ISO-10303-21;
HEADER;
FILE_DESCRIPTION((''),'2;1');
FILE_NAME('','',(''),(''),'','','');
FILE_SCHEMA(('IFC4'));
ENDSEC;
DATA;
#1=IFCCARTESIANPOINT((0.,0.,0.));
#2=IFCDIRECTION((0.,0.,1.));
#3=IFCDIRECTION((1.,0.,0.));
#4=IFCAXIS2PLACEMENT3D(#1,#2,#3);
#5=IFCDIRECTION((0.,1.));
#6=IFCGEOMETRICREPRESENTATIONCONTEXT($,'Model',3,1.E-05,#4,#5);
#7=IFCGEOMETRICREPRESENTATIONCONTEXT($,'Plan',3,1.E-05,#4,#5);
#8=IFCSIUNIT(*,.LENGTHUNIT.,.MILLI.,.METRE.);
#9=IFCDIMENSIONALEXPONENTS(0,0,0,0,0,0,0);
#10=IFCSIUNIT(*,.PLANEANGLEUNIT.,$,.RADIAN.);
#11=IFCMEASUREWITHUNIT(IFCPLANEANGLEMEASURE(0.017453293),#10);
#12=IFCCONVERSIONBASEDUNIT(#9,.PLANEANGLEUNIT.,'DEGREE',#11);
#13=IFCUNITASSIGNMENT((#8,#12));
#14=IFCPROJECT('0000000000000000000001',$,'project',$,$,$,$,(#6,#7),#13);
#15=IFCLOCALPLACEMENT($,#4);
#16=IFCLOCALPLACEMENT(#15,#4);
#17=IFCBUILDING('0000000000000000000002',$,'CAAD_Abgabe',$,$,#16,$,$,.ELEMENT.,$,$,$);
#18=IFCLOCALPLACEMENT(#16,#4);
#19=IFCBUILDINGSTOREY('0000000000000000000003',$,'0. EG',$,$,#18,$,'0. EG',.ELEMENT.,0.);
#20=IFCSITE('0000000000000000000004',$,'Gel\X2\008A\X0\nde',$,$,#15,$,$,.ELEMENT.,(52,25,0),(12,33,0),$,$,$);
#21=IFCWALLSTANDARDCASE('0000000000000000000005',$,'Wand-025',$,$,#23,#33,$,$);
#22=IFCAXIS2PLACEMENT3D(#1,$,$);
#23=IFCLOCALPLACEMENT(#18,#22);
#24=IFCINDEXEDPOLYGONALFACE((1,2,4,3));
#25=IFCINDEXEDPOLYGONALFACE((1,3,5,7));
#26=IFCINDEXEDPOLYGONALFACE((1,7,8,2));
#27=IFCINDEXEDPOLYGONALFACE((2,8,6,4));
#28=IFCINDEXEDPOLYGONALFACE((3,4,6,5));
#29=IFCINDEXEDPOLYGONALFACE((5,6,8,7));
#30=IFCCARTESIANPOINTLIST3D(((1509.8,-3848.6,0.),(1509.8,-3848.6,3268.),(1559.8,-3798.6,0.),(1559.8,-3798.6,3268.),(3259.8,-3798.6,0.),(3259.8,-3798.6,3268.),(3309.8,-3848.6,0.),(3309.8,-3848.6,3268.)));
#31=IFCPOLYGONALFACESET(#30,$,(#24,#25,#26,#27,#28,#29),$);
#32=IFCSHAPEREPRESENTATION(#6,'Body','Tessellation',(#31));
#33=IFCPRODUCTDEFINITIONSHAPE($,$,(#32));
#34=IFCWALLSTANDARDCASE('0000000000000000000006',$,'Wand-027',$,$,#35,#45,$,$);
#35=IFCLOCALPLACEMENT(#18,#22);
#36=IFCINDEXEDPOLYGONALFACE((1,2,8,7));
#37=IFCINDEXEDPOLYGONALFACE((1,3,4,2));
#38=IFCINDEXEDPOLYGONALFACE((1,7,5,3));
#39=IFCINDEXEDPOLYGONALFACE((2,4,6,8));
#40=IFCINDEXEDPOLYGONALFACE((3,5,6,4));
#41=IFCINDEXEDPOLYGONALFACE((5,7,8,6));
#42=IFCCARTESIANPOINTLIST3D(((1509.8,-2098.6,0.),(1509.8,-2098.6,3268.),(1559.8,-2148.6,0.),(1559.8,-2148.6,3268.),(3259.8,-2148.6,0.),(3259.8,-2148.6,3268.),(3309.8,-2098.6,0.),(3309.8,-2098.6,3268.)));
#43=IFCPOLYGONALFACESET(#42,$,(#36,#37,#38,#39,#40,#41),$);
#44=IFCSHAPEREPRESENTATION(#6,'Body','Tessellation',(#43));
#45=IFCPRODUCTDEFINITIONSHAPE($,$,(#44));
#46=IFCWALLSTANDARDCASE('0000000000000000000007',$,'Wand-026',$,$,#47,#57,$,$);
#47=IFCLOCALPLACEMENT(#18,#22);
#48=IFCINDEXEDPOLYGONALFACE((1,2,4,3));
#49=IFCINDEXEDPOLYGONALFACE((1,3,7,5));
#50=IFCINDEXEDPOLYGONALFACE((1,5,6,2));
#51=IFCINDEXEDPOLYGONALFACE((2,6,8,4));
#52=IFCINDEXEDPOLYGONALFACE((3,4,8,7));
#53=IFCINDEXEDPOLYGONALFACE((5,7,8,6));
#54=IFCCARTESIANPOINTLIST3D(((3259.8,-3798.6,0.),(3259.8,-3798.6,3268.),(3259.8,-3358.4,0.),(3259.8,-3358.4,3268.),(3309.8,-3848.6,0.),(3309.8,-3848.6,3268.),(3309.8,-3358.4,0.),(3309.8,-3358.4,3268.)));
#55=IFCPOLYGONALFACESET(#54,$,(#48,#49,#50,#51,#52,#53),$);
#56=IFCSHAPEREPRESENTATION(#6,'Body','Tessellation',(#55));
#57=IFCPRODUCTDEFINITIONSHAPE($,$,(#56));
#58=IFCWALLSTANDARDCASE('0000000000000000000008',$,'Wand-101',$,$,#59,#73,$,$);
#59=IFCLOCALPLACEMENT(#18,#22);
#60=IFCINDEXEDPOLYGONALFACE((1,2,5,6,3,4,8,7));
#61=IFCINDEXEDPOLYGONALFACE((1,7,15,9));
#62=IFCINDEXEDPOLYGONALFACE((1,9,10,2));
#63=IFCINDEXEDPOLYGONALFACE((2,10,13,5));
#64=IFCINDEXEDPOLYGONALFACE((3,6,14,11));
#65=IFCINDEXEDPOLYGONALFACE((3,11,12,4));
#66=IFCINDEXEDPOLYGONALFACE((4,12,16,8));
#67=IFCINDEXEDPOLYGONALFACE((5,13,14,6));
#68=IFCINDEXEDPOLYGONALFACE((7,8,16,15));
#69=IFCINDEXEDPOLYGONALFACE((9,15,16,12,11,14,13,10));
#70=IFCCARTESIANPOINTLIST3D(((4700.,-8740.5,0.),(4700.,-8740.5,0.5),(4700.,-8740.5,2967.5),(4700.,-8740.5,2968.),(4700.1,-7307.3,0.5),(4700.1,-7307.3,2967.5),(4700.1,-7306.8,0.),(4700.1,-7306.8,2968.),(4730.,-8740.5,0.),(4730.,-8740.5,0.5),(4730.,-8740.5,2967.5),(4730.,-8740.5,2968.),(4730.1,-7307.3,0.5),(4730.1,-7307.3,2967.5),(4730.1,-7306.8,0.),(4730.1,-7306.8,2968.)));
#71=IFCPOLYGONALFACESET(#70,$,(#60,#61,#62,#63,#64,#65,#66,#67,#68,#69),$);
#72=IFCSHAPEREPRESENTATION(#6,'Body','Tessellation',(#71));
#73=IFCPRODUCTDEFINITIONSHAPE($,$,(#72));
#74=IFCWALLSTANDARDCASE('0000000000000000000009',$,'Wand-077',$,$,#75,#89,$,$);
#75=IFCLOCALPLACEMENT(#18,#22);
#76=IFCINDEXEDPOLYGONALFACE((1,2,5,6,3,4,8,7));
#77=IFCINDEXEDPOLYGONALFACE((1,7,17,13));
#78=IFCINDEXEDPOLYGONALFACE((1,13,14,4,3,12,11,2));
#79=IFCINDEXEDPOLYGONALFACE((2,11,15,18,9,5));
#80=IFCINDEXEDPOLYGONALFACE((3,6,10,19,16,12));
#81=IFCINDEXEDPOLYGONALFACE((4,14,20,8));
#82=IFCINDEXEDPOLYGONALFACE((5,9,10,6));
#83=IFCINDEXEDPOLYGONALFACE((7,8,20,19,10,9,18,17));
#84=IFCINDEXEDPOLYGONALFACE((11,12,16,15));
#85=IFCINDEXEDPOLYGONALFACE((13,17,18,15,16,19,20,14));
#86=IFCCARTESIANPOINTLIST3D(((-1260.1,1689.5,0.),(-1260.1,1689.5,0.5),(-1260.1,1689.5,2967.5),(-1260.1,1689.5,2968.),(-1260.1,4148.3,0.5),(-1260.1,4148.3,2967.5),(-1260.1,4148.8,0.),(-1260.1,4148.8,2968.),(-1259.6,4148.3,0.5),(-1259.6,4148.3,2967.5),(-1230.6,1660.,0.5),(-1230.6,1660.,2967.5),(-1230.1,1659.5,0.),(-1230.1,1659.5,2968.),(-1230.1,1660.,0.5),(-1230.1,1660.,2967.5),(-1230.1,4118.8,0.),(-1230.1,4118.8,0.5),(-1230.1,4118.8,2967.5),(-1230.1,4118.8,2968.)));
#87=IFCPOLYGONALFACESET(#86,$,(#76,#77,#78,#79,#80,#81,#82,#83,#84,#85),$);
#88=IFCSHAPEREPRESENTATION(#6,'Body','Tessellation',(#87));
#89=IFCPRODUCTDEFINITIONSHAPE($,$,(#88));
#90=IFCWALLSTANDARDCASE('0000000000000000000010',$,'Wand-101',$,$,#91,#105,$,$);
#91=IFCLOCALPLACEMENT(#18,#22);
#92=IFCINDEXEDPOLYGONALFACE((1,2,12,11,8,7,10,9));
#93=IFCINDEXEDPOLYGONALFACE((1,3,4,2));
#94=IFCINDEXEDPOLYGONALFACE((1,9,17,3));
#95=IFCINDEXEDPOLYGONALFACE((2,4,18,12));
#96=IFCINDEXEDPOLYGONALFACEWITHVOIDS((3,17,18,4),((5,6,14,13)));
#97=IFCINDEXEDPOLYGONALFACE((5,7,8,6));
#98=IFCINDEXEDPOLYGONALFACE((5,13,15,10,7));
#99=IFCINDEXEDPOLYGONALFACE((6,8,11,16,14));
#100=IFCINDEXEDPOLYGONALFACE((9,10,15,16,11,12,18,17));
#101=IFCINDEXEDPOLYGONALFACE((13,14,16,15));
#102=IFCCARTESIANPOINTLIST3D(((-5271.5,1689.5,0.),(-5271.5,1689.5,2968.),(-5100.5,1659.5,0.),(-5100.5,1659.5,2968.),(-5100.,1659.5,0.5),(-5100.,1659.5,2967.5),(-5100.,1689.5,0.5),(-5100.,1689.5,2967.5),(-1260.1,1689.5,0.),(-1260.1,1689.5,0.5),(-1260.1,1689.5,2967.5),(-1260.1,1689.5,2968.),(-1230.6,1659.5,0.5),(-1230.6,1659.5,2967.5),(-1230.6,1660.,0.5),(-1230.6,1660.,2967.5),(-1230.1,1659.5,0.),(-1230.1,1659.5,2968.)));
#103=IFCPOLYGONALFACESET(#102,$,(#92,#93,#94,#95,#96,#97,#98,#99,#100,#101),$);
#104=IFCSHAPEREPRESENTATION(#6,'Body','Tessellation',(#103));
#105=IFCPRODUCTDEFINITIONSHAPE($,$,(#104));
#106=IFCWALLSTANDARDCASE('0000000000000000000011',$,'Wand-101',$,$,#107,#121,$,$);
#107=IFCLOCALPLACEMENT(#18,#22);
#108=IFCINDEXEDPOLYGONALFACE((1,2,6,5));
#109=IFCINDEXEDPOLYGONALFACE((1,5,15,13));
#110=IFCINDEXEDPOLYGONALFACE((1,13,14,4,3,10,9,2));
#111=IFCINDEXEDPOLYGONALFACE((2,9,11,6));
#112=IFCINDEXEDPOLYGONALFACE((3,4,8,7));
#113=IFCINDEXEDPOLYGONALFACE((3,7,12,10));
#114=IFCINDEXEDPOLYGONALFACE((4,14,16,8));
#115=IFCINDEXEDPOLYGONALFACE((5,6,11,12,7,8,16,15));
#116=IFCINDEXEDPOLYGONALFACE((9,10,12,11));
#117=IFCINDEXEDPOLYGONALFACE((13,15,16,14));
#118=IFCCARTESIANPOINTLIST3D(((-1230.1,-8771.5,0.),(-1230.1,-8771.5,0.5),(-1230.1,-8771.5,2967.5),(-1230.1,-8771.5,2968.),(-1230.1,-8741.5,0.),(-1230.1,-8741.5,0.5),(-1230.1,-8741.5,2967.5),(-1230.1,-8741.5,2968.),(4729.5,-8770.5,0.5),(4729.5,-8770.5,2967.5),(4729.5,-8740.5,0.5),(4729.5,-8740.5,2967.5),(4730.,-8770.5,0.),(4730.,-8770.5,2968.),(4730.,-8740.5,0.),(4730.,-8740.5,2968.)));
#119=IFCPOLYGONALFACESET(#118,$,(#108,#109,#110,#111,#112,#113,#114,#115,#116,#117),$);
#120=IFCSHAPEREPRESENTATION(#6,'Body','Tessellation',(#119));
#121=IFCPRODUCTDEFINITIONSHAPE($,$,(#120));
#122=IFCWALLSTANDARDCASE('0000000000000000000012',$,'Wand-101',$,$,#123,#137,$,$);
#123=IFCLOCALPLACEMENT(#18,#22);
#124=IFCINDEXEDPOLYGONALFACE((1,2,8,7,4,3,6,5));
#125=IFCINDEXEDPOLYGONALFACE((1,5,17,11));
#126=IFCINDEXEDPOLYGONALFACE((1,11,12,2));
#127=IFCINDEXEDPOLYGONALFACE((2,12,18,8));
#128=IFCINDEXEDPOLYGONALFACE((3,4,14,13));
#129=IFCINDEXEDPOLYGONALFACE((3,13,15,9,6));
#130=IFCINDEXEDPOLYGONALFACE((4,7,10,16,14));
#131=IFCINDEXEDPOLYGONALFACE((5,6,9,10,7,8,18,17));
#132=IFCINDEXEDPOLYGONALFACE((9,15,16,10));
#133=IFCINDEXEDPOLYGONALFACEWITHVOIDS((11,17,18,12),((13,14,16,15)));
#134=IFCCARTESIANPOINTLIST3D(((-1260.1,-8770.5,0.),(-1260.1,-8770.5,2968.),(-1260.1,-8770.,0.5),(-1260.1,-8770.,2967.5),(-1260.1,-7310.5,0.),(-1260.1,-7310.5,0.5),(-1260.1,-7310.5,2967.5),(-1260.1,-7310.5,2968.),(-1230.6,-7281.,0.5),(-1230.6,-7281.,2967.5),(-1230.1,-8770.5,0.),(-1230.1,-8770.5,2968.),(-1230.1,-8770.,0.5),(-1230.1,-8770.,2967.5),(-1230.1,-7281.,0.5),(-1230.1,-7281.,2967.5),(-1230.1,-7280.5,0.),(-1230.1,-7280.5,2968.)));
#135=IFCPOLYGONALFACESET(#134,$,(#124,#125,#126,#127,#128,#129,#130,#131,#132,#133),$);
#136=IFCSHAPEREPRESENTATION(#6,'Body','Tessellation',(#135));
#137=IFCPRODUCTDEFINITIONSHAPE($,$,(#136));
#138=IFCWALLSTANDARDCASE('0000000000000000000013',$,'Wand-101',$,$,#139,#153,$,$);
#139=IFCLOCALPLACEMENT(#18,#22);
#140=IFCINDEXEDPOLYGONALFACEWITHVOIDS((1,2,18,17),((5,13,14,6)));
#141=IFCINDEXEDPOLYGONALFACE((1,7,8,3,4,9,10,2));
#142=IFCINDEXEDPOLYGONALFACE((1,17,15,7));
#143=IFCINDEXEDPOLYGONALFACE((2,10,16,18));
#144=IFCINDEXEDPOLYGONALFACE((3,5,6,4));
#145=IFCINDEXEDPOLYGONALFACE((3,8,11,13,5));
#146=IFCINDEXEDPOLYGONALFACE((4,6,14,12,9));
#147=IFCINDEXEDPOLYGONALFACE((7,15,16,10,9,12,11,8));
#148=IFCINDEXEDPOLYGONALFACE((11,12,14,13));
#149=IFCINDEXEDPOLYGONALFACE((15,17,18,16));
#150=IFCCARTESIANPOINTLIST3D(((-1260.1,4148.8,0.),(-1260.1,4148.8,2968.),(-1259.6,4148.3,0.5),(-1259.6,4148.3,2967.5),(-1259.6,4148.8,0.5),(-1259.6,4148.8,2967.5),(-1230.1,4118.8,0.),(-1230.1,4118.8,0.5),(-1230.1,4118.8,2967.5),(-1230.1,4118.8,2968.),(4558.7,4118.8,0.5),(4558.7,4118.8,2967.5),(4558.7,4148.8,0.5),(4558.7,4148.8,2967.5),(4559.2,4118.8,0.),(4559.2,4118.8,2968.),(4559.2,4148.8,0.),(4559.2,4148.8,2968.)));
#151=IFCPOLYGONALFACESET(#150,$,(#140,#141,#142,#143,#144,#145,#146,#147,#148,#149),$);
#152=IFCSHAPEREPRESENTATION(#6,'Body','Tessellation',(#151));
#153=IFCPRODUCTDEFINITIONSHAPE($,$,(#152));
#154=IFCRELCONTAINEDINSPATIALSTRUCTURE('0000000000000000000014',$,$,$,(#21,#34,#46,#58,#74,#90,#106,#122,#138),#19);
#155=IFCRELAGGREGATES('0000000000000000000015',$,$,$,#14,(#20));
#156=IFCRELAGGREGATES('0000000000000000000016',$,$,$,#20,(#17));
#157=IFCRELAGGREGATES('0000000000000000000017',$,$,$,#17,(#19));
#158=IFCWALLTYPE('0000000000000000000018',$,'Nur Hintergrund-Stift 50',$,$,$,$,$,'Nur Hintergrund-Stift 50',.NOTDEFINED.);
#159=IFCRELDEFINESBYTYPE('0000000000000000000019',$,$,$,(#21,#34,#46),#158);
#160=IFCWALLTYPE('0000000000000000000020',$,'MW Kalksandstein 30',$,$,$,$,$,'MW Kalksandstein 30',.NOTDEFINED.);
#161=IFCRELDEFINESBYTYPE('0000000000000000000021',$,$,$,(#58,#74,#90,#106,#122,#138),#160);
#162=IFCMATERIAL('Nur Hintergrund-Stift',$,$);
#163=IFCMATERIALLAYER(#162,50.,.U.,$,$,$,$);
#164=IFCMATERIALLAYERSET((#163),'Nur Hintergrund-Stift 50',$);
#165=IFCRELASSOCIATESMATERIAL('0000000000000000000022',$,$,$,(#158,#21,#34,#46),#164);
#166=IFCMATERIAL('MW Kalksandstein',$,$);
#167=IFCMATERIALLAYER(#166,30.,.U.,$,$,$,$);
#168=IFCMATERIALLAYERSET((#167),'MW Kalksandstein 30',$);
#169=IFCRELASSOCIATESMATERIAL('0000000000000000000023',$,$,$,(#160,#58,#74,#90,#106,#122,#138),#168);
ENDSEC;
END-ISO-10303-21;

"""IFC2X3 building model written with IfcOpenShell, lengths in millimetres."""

from ifc_helpers import new_model, entity, si_unit, converted_unit, direction, frame, frame_2d, origin_with_axes, place, context, project, spatial, polyline, rectangle, outline, extrude, material, layer, layer_set, layer_usage, type_object, element, save


model = new_model("IFC2X3")

# Units and contexts
model_context = context("Model", 3, precision=1e-05, world=origin_with_axes(), true_north=direction((0.0, 1.0)))
plan_context = context("Plan", 3, precision=1e-05, world=origin_with_axes(), true_north=direction((0.0, 1.0)))
ifc_project = project(units=[si_unit("LENGTHUNIT", "METRE", prefix="MILLI"), converted_unit("PLANEANGLEUNIT", "DEGREE", entity("IfcPlaneAngleMeasure", 0.017453293), si_unit("PLANEANGLEUNIT", "RADIAN"), dimensions=[0, 0, 0, 0, 0, 0, 0])], contexts=[model_context, plan_context])

# Site, building, storey
site_placement = place(None, origin_with_axes())
site = spatial("IfcSite", under=ifc_project, at=site_placement, Name="Gel\u008ande", CompositionType="ELEMENT", RefLatitude=(52, 25, 0), RefLongitude=(12, 33, 0))
building_placement = place(site_placement, origin_with_axes())
building = spatial("IfcBuilding", under=site, at=building_placement, Name="CAAD_Abgabe", CompositionType="ELEMENT")
storey_placement = place(building_placement, origin_with_axes())
storey = spatial("IfcBuildingStorey", under=building, at=storey_placement, Name="0. EG", LongName="0. EG", CompositionType="ELEMENT", Elevation=0.0)

# Walls
ifc_material_1 = material(Name="Nur Hintergrund-Stift")
ifc_layer_1 = layer(ifc_material_1, 50.0, ventilated="UNKNOWN")
ifc_layer_set_1 = layer_set([ifc_layer_1], Name="Nur Hintergrund-Stift 50")
wall_type_1 = type_object("IfcWallType", Name="Nur Hintergrund-Stift 50", ElementType="Nur Hintergrund-Stift 50", PredefinedType="NOTDEFINED", material=ifc_layer_set_1)
ifc_layer_usage_1 = layer_usage(ifc_layer_set_1, "AXIS2", "NEGATIVE", 0.0)
wall_1_placement = place(storey_placement, frame((1559.8, -3798.6, 0.0), z_axis=(0.0, 0.0, 1.0), x_axis=(1.0, 0.0, 0.0)))
element("IfcWallStandardCase", 1, at=wall_1_placement, inside=storey, type_object=wall_type_1, material=ifc_layer_usage_1, Name="Wand-025", context=model_context, shape_type="SweptSolid", body=[
    extrude(outline(polyline([(-50.0, -50.0), (1750.0, -50.0), (1700.0, 0.0), (0.0, 0.0), (-50.0, -50.0)])), origin_with_axes(), (0.0, 0.0, 1.0), 3268.0),
])
ifc_layer_usage_2 = layer_usage(ifc_layer_set_1, "AXIS2", "NEGATIVE", 0.0)
wall_2_placement = place(storey_placement, frame((3309.8, -2148.6, 0.0), z_axis=(0.0, 0.0, 1.0), x_axis=(-1.0, 0.0, 0.0)))
element("IfcWallStandardCase", 2, at=wall_2_placement, inside=storey, type_object=wall_type_1, material=ifc_layer_usage_2, Name="Wand-027", context=model_context, shape_type="SweptSolid", body=[
    extrude(outline(polyline([(0.0, -50.0), (1800.0, -50.0), (1750.0, 0.0), (50.0, 0.0), (0.0, -50.0)])), origin_with_axes(), (0.0, 0.0, 1.0), 3268.0),
])
ifc_layer_usage_3 = layer_usage(ifc_layer_set_1, "AXIS2", "POSITIVE", 0.0)
wall_3_placement = place(storey_placement, frame((3309.8, -3798.6, 0.0), z_axis=(0.0, 0.0, 1.0), x_axis=(0.0, 1.0, 0.0)))
element("IfcWallStandardCase", 3, at=wall_3_placement, inside=storey, type_object=wall_type_1, material=ifc_layer_usage_3, Name="Wand-026", context=model_context, shape_type="SweptSolid", body=[
    extrude(outline(polyline([(-50.0, 0.0), (440.2, 0.0), (440.2, 50.0), (0.0, 50.0), (-50.0, 0.0)])), origin_with_axes(), (0.0, 0.0, 1.0), 3268.0),
])

# Walls, openings
ifc_material_2 = material(Name="MW Kalksandstein")
ifc_layer_2 = layer(ifc_material_2, 30.0, ventilated="UNKNOWN")
ifc_layer_set_2 = layer_set([ifc_layer_2], Name="MW Kalksandstein 30")
ifc_layer_usage_4 = layer_usage(ifc_layer_set_2, "AXIS2", "NEGATIVE", 0.0)
wall_type_2 = type_object("IfcWallType", Name="MW Kalksandstein 30", ElementType="MW Kalksandstein 30", PredefinedType="NOTDEFINED", material=ifc_layer_set_2)
wall_4_placement = place(storey_placement, frame((4700.0, -8740.5, 0.0), z_axis=(0.0, 0.0, 1.0), x_axis=(0.000045, 1.0, 0.0)))
wall_4 = element("IfcWallStandardCase", 4, at=wall_4_placement, inside=storey, type_object=wall_type_2, material=ifc_layer_usage_4, Name="Wand-101", context=model_context, shape_type="SweptSolid", body=[
    extrude(outline(polyline([(0.0, -30.0), (1433.7, -30.0), (1433.7, 0.0), (0.0, 0.0), (0.0, -30.0)])), origin_with_axes(), (0.0, 0.0, 1.0), 2968.0),
])
opening_1_placement = place(wall_4_placement, frame((701.9, -30.0, 0.0), z_axis=(0.0, 0.0, 1.0), x_axis=(1.0, 0.0, 0.0)))
element("IfcOpeningElement", 5, at=opening_1_placement, cuts=wall_4, ObjectType="Opening", context=model_context, shape_type="SweptSolid", body=[
    extrude(rectangle(XDim=1462.8, YDim=2967.0, at=frame_2d((0.0, 1484.0), x_axis=(1.0, 0.0))), frame((0.0, 0.0, 0.0), z_axis=(0.0, 1.0, 0.0), x_axis=(-1.0, 0.0, 0.0)), (0.0, 0.0, 1.0), 30.0),
])
ifc_layer_usage_5 = layer_usage(ifc_layer_set_2, "AXIS2", "POSITIVE", 0.0)
wall_5_placement = place(storey_placement, frame((-1230.1, 1689.5, 0.0), z_axis=(0.0, 0.0, 1.0), x_axis=(0.0, 1.0, 0.0)))
wall_5 = element("IfcWallStandardCase", 6, at=wall_5_placement, inside=storey, type_object=wall_type_2, material=ifc_layer_usage_5, Name="Wand-077", context=model_context, shape_type="SweptSolid", body=[
    extrude(outline(polyline([(-30.0, 0.0), (2429.3, 0.0), (2459.3, 30.0), (0.0, 30.0), (-30.0, 0.0)])), origin_with_axes(), (0.0, 0.0, 1.0), 2968.0),
])
opening_2_placement = place(wall_5_placement, frame((1214.7, 0.0, 0.0), z_axis=(0.0, 0.0, 1.0), x_axis=(1.0, 0.0, 0.0)))
element("IfcOpeningElement", 7, at=opening_2_placement, cuts=wall_5, ObjectType="Opening", context=model_context, shape_type="SweptSolid", body=[
    extrude(rectangle(XDim=2488.3, YDim=2967.0, at=frame_2d((0.0, 1484.0), x_axis=(1.0, 0.0))), frame((0.0, 0.0, 0.0), z_axis=(0.0, 1.0, 0.0), x_axis=(-1.0, 0.0, 0.0)), (0.0, 0.0, 1.0), 30.0),
])
ifc_layer_usage_6 = layer_usage(ifc_layer_set_2, "AXIS2", "NEGATIVE", 0.0)
wall_6_placement = place(storey_placement, frame((-5271.5, 1689.5, 0.0), z_axis=(0.0, 0.0, 1.0), x_axis=(1.0, 0.0, 0.0)))
wall_6 = element("IfcWallStandardCase", 8, at=wall_6_placement, inside=storey, type_object=wall_type_2, material=ifc_layer_usage_6, Name="Wand-101", context=model_context, shape_type="SweptSolid", body=[
    extrude(outline(polyline([(171.0, -30.0), (4041.4, -30.0), (4011.4, 0.0), (0.0, 0.0), (171.0, -30.0)])), origin_with_axes(), (0.0, 0.0, 1.0), 2968.0),
])
opening_3_placement = place(wall_6_placement, frame((2106.2, -30.0, 0.0), z_axis=(0.0, 0.0, 1.0), x_axis=(1.0, 0.0, 0.0)))
element("IfcOpeningElement", 9, at=opening_3_placement, cuts=wall_6, ObjectType="Opening", context=model_context, shape_type="SweptSolid", body=[
    extrude(rectangle(XDim=3869.4, YDim=2967.0, at=frame_2d((0.0, 1484.0), x_axis=(1.0, 0.0))), frame((0.0, 0.0, 0.0), z_axis=(0.0, 1.0, 0.0), x_axis=(-1.0, 0.0, 0.0)), (0.0, 0.0, 1.0), 30.0),
])
ifc_layer_usage_7 = layer_usage(ifc_layer_set_2, "AXIS2", "NEGATIVE", 0.0)
wall_7_placement = place(storey_placement, frame((-1230.1, -8741.5, 0.0), z_axis=(0.0, 0.0, 1.0), x_axis=(1.0, 0.000154, 0.0)))
wall_7 = element("IfcWallStandardCase", 10, at=wall_7_placement, inside=storey, type_object=wall_type_2, material=ifc_layer_usage_7, Name="Wand-101", context=model_context, shape_type="SweptSolid", body=[
    extrude(outline(polyline([(0.0, -30.0), (5960.1, -30.0), (5960.1, 0.0), (0.0, 0.0), (0.0, -30.0)])), origin_with_axes(), (0.0, 0.0, 1.0), 2968.0),
])
opening_4_placement = place(wall_7_placement, frame((2965.1, -30.0, 0.0), z_axis=(0.0, 0.0, 1.0), x_axis=(1.0, 0.0, 0.0)))
element("IfcOpeningElement", 11, at=opening_4_placement, cuts=wall_7, ObjectType="Opening", context=model_context, shape_type="SweptSolid", body=[
    extrude(rectangle(XDim=5989.1, YDim=2967.0, at=frame_2d((0.0, 1484.0), x_axis=(1.0, 0.0))), frame((0.0, 0.0, 0.0), z_axis=(0.0, 1.0, 0.0), x_axis=(-1.0, 0.0, 0.0)), (0.0, 0.0, 1.0), 30.0),
])
ifc_layer_usage_8 = layer_usage(ifc_layer_set_2, "AXIS2", "NEGATIVE", 0.0)
wall_8_placement = place(storey_placement, frame((-1230.1, -7280.5, 0.0), z_axis=(0.0, 0.0, 1.0), x_axis=(0.0, -1.0, 0.0)))
wall_8 = element("IfcWallStandardCase", 12, at=wall_8_placement, inside=storey, type_object=wall_type_2, material=ifc_layer_usage_8, Name="Wand-101", context=model_context, shape_type="SweptSolid", body=[
    extrude(outline(polyline([(30.0, -30.0), (1490.0, -30.0), (1490.0, 0.0), (0.0, 0.0), (30.0, -30.0)])), origin_with_axes(), (0.0, 0.0, 1.0), 2968.0),
])
opening_5_placement = place(wall_8_placement, frame((745.0, -30.0, 0.0), z_axis=(0.0, 0.0, 1.0), x_axis=(1.0, 0.0, 0.0)))
element("IfcOpeningElement", 13, at=opening_5_placement, cuts=wall_8, ObjectType="Opening", context=model_context, shape_type="SweptSolid", body=[
    extrude(rectangle(XDim=1489.0, YDim=2967.0, at=frame_2d((0.0, 1484.0), x_axis=(1.0, 0.0))), frame((0.0, 0.0, 0.0), z_axis=(0.0, 1.0, 0.0), x_axis=(-1.0, 0.0, 0.0)), (0.0, 0.0, 1.0), 30.0),
])
ifc_layer_usage_9 = layer_usage(ifc_layer_set_2, "AXIS2", "NEGATIVE", 0.0)
wall_9_placement = place(storey_placement, frame((-1230.1, 4148.8, 0.0), z_axis=(0.0, 0.0, 1.0), x_axis=(1.0, 0.0, 0.0)))
wall_9 = element("IfcWallStandardCase", 14, at=wall_9_placement, inside=storey, type_object=wall_type_2, material=ifc_layer_usage_9, Name="Wand-101", context=model_context, shape_type="SweptSolid", body=[
    extrude(outline(polyline([(0.0, -30.0), (5789.3, -30.0), (5789.3, 0.0), (-30.0, 0.0), (0.0, -30.0)])), origin_with_axes(), (0.0, 0.0, 1.0), 2968.0),
])
opening_6_placement = place(wall_9_placement, frame((2879.6, -30.0, 0.0), z_axis=(0.0, 0.0, 1.0), x_axis=(1.0, 0.0, 0.0)))
element("IfcOpeningElement", 15, at=opening_6_placement, cuts=wall_9, ObjectType="Opening", context=model_context, shape_type="SweptSolid", body=[
    extrude(rectangle(XDim=5818.3, YDim=2967.0, at=frame_2d((0.0, 1484.0), x_axis=(1.0, 0.0))), frame((0.0, 0.0, 0.0), z_axis=(0.0, 1.0, 0.0), x_axis=(-1.0, 0.0, 0.0)), (0.0, 0.0, 1.0), 30.0),
])

save(model, "model.ifc")
